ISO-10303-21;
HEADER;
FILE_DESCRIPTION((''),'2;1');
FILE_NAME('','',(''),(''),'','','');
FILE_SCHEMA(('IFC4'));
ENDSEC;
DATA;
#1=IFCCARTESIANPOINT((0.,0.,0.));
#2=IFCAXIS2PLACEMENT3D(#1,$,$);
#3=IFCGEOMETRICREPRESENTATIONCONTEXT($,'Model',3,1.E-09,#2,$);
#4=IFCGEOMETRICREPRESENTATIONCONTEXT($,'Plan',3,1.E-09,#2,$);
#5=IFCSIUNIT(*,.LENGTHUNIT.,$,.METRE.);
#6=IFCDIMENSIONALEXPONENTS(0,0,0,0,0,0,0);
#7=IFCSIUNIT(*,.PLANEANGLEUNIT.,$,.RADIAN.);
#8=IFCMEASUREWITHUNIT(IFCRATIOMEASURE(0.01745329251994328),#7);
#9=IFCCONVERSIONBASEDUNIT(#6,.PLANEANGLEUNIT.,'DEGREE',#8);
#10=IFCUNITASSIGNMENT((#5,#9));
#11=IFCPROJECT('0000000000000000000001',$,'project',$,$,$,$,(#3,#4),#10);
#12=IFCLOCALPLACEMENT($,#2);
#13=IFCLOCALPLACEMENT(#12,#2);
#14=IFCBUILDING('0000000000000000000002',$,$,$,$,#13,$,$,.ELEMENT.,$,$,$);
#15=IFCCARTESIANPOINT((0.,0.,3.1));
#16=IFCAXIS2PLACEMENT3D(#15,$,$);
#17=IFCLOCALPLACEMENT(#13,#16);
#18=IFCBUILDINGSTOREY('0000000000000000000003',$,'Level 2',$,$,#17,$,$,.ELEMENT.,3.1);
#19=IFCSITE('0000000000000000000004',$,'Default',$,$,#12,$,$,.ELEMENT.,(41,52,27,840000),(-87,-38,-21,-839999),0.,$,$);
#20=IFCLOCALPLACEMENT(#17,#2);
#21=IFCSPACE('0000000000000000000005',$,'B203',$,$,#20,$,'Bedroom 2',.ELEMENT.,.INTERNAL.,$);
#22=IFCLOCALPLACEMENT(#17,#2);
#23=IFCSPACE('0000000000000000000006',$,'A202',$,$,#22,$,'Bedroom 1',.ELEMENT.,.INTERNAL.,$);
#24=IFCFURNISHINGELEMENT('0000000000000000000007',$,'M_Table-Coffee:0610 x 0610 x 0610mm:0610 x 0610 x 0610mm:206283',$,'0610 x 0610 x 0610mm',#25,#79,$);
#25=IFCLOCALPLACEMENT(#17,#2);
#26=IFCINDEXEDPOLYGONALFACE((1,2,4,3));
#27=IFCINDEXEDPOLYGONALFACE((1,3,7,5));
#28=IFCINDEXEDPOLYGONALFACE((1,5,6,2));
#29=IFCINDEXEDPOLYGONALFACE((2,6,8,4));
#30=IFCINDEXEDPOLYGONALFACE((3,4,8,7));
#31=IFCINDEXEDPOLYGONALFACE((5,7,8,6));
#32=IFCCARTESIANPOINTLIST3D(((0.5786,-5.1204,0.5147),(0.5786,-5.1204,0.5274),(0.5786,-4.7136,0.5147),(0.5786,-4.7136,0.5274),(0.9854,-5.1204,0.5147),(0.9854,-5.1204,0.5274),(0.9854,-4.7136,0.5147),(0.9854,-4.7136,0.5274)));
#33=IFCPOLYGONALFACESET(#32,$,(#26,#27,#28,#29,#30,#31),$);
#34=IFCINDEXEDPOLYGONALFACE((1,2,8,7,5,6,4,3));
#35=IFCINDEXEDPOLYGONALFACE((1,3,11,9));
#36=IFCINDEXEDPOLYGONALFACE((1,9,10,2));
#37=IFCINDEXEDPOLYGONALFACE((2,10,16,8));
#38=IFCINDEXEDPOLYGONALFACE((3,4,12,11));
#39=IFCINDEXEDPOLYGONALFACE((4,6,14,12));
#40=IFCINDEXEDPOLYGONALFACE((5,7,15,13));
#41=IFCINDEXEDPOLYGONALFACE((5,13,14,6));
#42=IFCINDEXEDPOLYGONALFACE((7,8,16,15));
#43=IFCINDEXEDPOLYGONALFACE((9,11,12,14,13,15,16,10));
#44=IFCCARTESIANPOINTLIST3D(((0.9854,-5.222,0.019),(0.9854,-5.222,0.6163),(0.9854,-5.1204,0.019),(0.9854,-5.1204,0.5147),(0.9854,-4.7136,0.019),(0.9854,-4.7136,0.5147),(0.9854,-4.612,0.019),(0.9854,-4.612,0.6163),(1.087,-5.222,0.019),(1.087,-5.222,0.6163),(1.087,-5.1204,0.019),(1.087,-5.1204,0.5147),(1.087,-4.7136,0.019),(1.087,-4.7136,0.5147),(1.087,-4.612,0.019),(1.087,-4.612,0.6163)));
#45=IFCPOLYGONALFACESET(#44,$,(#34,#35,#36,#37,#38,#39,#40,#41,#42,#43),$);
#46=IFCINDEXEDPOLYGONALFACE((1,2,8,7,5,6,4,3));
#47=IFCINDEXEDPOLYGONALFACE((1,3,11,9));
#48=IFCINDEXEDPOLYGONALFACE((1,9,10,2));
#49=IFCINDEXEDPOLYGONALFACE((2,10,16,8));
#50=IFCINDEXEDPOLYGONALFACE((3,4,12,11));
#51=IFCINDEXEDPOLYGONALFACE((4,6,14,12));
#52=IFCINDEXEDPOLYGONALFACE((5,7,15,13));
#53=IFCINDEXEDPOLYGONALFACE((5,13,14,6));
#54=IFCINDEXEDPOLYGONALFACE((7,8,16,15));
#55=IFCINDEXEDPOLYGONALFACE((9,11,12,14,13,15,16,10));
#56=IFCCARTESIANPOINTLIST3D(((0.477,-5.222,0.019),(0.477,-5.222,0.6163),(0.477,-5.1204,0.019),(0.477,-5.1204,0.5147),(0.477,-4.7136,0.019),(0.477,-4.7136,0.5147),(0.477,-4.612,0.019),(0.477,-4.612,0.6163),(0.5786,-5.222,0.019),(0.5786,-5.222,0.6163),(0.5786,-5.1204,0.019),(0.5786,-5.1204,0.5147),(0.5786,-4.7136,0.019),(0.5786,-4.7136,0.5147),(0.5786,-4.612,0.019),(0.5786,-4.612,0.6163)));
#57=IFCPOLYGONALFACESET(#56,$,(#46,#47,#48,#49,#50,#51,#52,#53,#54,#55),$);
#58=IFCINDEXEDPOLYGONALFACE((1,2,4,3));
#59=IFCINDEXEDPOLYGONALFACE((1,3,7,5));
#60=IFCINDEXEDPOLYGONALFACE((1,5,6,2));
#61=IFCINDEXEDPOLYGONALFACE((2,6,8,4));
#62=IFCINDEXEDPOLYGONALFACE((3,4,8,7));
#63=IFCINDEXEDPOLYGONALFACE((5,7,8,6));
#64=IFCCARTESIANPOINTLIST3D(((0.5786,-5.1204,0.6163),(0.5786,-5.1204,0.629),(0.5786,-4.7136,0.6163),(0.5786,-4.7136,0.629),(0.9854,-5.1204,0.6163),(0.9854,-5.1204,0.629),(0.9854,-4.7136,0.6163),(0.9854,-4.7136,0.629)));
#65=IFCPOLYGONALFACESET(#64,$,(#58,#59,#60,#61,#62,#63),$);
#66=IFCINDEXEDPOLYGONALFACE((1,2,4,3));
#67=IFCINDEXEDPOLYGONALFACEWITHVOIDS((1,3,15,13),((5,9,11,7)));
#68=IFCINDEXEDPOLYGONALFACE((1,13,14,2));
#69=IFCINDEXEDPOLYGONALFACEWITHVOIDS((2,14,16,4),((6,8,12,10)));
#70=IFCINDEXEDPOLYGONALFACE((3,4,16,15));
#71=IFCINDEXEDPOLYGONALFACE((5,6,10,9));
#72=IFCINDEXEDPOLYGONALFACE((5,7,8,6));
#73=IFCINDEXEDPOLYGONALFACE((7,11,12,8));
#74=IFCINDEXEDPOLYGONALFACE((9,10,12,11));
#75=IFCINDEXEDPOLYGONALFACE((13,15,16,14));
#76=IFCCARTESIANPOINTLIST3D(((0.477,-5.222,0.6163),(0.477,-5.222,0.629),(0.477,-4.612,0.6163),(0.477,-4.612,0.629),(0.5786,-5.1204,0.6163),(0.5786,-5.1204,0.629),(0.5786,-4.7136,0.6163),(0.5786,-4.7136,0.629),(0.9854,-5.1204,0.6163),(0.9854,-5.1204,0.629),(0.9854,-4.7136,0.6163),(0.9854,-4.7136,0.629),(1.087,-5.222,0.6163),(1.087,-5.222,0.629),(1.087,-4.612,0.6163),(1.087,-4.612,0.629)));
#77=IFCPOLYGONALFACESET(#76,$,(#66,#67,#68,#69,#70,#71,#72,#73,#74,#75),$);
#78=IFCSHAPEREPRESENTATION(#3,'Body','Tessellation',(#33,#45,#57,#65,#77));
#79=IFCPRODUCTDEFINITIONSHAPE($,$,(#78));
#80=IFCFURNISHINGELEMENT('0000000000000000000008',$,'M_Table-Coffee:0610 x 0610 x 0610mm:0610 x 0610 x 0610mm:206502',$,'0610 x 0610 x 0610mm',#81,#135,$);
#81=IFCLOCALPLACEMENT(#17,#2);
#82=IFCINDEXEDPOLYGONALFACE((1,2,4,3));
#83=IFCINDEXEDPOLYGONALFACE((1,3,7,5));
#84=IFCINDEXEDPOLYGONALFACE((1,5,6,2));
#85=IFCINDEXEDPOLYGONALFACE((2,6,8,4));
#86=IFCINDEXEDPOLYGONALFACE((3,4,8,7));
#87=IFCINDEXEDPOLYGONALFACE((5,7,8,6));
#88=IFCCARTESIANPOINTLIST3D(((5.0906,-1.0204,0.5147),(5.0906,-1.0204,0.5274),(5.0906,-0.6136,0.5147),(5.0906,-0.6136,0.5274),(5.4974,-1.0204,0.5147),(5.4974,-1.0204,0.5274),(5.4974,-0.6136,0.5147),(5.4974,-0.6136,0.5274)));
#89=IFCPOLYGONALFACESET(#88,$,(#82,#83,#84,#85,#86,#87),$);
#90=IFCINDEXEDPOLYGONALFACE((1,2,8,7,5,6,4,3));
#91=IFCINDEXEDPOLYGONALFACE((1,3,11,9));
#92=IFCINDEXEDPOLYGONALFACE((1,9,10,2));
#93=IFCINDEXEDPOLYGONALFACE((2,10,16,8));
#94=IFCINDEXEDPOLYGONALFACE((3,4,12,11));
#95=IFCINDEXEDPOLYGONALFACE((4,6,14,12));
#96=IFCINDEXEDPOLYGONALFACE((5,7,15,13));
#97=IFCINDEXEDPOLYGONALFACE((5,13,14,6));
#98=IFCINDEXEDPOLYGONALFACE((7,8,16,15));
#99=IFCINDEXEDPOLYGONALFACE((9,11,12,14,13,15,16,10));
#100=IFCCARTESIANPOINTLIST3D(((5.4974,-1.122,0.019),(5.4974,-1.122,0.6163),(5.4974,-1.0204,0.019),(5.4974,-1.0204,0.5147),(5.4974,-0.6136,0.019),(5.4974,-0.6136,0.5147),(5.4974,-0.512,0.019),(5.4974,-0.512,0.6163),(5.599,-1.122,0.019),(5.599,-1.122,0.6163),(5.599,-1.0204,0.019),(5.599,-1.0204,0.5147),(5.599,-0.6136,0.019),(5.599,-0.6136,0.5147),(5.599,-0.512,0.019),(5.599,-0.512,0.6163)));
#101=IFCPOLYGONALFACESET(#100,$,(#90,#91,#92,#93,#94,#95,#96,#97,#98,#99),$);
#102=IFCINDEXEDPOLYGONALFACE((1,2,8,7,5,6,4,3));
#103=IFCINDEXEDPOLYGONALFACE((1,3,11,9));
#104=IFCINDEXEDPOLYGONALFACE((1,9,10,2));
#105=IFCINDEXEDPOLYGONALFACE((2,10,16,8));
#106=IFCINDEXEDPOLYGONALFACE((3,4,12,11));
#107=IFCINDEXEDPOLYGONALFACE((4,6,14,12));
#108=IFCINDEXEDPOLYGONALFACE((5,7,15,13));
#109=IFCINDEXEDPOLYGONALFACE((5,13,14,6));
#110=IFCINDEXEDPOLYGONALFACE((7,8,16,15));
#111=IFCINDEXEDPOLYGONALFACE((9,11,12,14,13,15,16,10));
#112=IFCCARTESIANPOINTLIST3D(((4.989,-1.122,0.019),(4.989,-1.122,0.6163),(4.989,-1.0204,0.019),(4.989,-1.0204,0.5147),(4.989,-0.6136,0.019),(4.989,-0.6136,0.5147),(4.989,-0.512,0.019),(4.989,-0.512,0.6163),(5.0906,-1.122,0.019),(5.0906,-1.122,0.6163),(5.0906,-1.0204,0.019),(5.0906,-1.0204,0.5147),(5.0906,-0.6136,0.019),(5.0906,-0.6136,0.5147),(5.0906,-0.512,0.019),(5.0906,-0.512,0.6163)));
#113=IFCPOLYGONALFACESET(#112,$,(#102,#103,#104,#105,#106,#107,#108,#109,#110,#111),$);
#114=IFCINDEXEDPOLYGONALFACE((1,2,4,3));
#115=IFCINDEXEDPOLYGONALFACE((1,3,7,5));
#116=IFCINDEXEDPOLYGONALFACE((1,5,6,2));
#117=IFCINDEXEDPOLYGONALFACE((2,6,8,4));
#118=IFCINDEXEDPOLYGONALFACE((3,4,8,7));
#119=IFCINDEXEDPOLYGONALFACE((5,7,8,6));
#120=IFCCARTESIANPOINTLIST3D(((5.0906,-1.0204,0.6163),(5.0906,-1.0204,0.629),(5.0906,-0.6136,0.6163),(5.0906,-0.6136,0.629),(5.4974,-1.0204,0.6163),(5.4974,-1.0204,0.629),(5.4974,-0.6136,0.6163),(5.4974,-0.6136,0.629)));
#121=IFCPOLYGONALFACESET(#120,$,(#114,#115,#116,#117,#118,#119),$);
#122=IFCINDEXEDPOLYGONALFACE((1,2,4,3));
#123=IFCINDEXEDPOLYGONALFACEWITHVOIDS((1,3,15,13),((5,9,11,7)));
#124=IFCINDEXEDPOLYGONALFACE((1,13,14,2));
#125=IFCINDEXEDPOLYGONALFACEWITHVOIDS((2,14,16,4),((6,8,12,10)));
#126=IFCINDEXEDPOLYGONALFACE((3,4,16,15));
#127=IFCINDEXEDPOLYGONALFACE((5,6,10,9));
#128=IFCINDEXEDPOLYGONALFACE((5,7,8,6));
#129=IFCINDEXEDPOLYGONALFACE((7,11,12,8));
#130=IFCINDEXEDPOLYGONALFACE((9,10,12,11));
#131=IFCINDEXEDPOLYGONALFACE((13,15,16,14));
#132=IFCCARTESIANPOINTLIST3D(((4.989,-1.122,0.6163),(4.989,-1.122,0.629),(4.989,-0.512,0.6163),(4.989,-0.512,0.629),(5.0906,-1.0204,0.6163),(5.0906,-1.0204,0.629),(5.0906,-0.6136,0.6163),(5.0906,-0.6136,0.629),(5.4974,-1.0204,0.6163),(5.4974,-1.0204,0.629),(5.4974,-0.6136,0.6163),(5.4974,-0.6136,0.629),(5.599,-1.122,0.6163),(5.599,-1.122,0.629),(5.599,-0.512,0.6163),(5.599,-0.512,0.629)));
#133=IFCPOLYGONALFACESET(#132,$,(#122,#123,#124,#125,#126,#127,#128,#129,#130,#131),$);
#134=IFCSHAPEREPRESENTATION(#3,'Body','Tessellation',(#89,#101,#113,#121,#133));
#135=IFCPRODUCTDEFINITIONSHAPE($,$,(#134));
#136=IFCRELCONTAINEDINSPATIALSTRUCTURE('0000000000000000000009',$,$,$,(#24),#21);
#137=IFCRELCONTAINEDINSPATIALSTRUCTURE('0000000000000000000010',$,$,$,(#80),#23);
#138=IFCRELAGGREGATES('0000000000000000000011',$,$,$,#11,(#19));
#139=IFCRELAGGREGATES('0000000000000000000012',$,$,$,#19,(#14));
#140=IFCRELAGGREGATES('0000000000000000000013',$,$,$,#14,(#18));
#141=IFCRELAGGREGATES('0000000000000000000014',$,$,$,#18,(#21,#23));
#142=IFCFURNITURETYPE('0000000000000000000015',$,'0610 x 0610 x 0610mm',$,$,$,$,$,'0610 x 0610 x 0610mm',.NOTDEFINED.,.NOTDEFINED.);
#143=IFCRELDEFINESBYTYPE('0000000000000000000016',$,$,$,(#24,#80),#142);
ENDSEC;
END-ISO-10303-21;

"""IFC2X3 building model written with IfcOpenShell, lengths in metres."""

from ifc_helpers import new_model, entity, si_unit, converted_unit, frame, origin, origin_2d_with_axis, place, context, project, spatial, polyline, rectangle, outline, extrude, source, transform, mapped, type_object, type_shapes, element, save


model = new_model("IFC2X3")

# Units and contexts
model_context = context("Model", 3, precision=1e-09, world=origin())
plan_context = context("Plan", 3, precision=1e-09, world=origin())
ifc_project = project(units=[si_unit("LENGTHUNIT", "METRE"), converted_unit("PLANEANGLEUNIT", "DEGREE", entity("IfcRatioMeasure", 0.01745329251994328), si_unit("PLANEANGLEUNIT", "RADIAN"), dimensions=[0, 0, 0, 0, 0, 0, 0])], contexts=[model_context, plan_context])

# Site, building, storey
site_placement = place(None, origin())
site = spatial("IfcSite", under=ifc_project, at=site_placement, Name="Default", CompositionType="ELEMENT", RefLatitude=(41, 52, 27, 840000), RefLongitude=(-87, -38, -21, -839999), RefElevation=0.0)
building_placement = place(site_placement, origin())
building = spatial("IfcBuilding", under=site, at=building_placement, CompositionType="ELEMENT")
storey_placement = place(building_placement, frame((0.0, 0.0, 3.1)))
storey = spatial("IfcBuildingStorey", under=building, at=storey_placement, Name="Level 2", CompositionType="ELEMENT", Elevation=3.1)

# Shared definitions
space_1_placement = place(storey_placement, origin())
space_1 = spatial("IfcSpace", under=storey, at=space_1_placement, Name="B203", LongName="Bedroom 2", CompositionType="ELEMENT", InteriorOrExteriorSpace="INTERNAL")

# Furnishing element
furniture_type = type_object("IfcFurnitureType", Name="0610 x 0610 x 0610mm", ElementType="0610 x 0610 x 0610mm", AssemblyPlace="NOTDEFINED")
shared_shape_1 = source(origin(), model_context, "Body", "SweptSolid", [
    extrude(rectangle(XDim=0.4068, YDim=0.4068, at=origin_2d_with_axis()), frame((0.0183, 0.0952, 0.4957), z_axis=(0.0, 0.0, 1.0), x_axis=(-1.0, 0.0, 0.0)), (0.0, 0.0, 1.0), 0.0127),
    extrude(outline(polyline([(-0.2732, -0.305), (0.324, -0.305), (0.324, 0.305), (-0.2732, 0.305), (-0.2732, 0.2034), (0.2225, 0.2034), (0.2225, -0.2034), (-0.2732, -0.2034), (-0.2732, -0.305)])), frame((0.2217, 0.0952, 0.2732), z_axis=(1.0, 0.0, 0.0), x_axis=(0.0, 0.0, 1.0)), (0.0, 0.0, 1.0), 0.1016),
    extrude(outline(polyline([(-0.305, -0.3241), (0.305, -0.3241), (0.305, 0.2733), (0.2034, 0.2733), (0.2034, -0.2224), (-0.2034, -0.2224), (-0.2034, 0.2733), (-0.305, 0.2733), (-0.305, -0.3241)])), frame((-0.2867, 0.0952, 0.2733), z_axis=(1.0, 0.0, 0.0), x_axis=(0.0, -1.0, 0.0)), (0.0, 0.0, 1.0), 0.1016),
    extrude(rectangle(XDim=0.4068, YDim=0.4068, at=origin_2d_with_axis()), frame((0.0183, 0.0952, 0.5973), z_axis=(0.0, 0.0, 1.0), x_axis=(-1.0, 0.0, 0.0)), (0.0, 0.0, 1.0), 0.0127),
    extrude(outline(polyline([(-0.305, -0.305), (0.305, -0.305), (0.305, 0.305), (-0.305, 0.305), (-0.305, -0.305)]), holes=[polyline([(-0.2034, -0.2034), (-0.2034, 0.2034), (0.2034, 0.2034), (0.2034, -0.2034), (-0.2034, -0.2034)])]), frame((0.0183, 0.0952, 0.5973), z_axis=(0.0, 0.0, 1.0), x_axis=(-1.0, 0.0, 0.0)), (0.0, 0.0, 1.0), 0.0127),
])
type_shapes(furniture_type, [shared_shape_1])
furnishing_1_placement = place(space_1_placement, frame((0.7637, -5.0122, 0.019)))
element("IfcFurnishingElement", 1, at=furnishing_1_placement, inside=space_1, type_object=furniture_type, Name="M_Table-Coffee:0610 x 0610 x 0610mm:0610 x 0610 x 0610mm:206283", ObjectType="0610 x 0610 x 0610mm", context=model_context, shape_type="MappedRepresentation", body=[
    mapped(shared_shape_1, transform((0.0, 0.0, 0.0), scale=1.0)),
])

# Shared definitions
space_2_placement = place(storey_placement, origin())
space_2 = spatial("IfcSpace", under=storey, at=space_2_placement, Name="A202", LongName="Bedroom 1", CompositionType="ELEMENT", InteriorOrExteriorSpace="INTERNAL")

# Furnishing element
furnishing_2_placement = place(space_2_placement, frame((5.2757, -0.9122, 0.019)))
element("IfcFurnishingElement", 2, at=furnishing_2_placement, inside=space_2, type_object=furniture_type, Name="M_Table-Coffee:0610 x 0610 x 0610mm:0610 x 0610 x 0610mm:206502", ObjectType="0610 x 0610 x 0610mm", context=model_context, shape_type="MappedRepresentation", body=[
    mapped(shared_shape_1, transform((0.0, 0.0, 0.0), scale=1.0)),
])

save(model, "model.ifc")
